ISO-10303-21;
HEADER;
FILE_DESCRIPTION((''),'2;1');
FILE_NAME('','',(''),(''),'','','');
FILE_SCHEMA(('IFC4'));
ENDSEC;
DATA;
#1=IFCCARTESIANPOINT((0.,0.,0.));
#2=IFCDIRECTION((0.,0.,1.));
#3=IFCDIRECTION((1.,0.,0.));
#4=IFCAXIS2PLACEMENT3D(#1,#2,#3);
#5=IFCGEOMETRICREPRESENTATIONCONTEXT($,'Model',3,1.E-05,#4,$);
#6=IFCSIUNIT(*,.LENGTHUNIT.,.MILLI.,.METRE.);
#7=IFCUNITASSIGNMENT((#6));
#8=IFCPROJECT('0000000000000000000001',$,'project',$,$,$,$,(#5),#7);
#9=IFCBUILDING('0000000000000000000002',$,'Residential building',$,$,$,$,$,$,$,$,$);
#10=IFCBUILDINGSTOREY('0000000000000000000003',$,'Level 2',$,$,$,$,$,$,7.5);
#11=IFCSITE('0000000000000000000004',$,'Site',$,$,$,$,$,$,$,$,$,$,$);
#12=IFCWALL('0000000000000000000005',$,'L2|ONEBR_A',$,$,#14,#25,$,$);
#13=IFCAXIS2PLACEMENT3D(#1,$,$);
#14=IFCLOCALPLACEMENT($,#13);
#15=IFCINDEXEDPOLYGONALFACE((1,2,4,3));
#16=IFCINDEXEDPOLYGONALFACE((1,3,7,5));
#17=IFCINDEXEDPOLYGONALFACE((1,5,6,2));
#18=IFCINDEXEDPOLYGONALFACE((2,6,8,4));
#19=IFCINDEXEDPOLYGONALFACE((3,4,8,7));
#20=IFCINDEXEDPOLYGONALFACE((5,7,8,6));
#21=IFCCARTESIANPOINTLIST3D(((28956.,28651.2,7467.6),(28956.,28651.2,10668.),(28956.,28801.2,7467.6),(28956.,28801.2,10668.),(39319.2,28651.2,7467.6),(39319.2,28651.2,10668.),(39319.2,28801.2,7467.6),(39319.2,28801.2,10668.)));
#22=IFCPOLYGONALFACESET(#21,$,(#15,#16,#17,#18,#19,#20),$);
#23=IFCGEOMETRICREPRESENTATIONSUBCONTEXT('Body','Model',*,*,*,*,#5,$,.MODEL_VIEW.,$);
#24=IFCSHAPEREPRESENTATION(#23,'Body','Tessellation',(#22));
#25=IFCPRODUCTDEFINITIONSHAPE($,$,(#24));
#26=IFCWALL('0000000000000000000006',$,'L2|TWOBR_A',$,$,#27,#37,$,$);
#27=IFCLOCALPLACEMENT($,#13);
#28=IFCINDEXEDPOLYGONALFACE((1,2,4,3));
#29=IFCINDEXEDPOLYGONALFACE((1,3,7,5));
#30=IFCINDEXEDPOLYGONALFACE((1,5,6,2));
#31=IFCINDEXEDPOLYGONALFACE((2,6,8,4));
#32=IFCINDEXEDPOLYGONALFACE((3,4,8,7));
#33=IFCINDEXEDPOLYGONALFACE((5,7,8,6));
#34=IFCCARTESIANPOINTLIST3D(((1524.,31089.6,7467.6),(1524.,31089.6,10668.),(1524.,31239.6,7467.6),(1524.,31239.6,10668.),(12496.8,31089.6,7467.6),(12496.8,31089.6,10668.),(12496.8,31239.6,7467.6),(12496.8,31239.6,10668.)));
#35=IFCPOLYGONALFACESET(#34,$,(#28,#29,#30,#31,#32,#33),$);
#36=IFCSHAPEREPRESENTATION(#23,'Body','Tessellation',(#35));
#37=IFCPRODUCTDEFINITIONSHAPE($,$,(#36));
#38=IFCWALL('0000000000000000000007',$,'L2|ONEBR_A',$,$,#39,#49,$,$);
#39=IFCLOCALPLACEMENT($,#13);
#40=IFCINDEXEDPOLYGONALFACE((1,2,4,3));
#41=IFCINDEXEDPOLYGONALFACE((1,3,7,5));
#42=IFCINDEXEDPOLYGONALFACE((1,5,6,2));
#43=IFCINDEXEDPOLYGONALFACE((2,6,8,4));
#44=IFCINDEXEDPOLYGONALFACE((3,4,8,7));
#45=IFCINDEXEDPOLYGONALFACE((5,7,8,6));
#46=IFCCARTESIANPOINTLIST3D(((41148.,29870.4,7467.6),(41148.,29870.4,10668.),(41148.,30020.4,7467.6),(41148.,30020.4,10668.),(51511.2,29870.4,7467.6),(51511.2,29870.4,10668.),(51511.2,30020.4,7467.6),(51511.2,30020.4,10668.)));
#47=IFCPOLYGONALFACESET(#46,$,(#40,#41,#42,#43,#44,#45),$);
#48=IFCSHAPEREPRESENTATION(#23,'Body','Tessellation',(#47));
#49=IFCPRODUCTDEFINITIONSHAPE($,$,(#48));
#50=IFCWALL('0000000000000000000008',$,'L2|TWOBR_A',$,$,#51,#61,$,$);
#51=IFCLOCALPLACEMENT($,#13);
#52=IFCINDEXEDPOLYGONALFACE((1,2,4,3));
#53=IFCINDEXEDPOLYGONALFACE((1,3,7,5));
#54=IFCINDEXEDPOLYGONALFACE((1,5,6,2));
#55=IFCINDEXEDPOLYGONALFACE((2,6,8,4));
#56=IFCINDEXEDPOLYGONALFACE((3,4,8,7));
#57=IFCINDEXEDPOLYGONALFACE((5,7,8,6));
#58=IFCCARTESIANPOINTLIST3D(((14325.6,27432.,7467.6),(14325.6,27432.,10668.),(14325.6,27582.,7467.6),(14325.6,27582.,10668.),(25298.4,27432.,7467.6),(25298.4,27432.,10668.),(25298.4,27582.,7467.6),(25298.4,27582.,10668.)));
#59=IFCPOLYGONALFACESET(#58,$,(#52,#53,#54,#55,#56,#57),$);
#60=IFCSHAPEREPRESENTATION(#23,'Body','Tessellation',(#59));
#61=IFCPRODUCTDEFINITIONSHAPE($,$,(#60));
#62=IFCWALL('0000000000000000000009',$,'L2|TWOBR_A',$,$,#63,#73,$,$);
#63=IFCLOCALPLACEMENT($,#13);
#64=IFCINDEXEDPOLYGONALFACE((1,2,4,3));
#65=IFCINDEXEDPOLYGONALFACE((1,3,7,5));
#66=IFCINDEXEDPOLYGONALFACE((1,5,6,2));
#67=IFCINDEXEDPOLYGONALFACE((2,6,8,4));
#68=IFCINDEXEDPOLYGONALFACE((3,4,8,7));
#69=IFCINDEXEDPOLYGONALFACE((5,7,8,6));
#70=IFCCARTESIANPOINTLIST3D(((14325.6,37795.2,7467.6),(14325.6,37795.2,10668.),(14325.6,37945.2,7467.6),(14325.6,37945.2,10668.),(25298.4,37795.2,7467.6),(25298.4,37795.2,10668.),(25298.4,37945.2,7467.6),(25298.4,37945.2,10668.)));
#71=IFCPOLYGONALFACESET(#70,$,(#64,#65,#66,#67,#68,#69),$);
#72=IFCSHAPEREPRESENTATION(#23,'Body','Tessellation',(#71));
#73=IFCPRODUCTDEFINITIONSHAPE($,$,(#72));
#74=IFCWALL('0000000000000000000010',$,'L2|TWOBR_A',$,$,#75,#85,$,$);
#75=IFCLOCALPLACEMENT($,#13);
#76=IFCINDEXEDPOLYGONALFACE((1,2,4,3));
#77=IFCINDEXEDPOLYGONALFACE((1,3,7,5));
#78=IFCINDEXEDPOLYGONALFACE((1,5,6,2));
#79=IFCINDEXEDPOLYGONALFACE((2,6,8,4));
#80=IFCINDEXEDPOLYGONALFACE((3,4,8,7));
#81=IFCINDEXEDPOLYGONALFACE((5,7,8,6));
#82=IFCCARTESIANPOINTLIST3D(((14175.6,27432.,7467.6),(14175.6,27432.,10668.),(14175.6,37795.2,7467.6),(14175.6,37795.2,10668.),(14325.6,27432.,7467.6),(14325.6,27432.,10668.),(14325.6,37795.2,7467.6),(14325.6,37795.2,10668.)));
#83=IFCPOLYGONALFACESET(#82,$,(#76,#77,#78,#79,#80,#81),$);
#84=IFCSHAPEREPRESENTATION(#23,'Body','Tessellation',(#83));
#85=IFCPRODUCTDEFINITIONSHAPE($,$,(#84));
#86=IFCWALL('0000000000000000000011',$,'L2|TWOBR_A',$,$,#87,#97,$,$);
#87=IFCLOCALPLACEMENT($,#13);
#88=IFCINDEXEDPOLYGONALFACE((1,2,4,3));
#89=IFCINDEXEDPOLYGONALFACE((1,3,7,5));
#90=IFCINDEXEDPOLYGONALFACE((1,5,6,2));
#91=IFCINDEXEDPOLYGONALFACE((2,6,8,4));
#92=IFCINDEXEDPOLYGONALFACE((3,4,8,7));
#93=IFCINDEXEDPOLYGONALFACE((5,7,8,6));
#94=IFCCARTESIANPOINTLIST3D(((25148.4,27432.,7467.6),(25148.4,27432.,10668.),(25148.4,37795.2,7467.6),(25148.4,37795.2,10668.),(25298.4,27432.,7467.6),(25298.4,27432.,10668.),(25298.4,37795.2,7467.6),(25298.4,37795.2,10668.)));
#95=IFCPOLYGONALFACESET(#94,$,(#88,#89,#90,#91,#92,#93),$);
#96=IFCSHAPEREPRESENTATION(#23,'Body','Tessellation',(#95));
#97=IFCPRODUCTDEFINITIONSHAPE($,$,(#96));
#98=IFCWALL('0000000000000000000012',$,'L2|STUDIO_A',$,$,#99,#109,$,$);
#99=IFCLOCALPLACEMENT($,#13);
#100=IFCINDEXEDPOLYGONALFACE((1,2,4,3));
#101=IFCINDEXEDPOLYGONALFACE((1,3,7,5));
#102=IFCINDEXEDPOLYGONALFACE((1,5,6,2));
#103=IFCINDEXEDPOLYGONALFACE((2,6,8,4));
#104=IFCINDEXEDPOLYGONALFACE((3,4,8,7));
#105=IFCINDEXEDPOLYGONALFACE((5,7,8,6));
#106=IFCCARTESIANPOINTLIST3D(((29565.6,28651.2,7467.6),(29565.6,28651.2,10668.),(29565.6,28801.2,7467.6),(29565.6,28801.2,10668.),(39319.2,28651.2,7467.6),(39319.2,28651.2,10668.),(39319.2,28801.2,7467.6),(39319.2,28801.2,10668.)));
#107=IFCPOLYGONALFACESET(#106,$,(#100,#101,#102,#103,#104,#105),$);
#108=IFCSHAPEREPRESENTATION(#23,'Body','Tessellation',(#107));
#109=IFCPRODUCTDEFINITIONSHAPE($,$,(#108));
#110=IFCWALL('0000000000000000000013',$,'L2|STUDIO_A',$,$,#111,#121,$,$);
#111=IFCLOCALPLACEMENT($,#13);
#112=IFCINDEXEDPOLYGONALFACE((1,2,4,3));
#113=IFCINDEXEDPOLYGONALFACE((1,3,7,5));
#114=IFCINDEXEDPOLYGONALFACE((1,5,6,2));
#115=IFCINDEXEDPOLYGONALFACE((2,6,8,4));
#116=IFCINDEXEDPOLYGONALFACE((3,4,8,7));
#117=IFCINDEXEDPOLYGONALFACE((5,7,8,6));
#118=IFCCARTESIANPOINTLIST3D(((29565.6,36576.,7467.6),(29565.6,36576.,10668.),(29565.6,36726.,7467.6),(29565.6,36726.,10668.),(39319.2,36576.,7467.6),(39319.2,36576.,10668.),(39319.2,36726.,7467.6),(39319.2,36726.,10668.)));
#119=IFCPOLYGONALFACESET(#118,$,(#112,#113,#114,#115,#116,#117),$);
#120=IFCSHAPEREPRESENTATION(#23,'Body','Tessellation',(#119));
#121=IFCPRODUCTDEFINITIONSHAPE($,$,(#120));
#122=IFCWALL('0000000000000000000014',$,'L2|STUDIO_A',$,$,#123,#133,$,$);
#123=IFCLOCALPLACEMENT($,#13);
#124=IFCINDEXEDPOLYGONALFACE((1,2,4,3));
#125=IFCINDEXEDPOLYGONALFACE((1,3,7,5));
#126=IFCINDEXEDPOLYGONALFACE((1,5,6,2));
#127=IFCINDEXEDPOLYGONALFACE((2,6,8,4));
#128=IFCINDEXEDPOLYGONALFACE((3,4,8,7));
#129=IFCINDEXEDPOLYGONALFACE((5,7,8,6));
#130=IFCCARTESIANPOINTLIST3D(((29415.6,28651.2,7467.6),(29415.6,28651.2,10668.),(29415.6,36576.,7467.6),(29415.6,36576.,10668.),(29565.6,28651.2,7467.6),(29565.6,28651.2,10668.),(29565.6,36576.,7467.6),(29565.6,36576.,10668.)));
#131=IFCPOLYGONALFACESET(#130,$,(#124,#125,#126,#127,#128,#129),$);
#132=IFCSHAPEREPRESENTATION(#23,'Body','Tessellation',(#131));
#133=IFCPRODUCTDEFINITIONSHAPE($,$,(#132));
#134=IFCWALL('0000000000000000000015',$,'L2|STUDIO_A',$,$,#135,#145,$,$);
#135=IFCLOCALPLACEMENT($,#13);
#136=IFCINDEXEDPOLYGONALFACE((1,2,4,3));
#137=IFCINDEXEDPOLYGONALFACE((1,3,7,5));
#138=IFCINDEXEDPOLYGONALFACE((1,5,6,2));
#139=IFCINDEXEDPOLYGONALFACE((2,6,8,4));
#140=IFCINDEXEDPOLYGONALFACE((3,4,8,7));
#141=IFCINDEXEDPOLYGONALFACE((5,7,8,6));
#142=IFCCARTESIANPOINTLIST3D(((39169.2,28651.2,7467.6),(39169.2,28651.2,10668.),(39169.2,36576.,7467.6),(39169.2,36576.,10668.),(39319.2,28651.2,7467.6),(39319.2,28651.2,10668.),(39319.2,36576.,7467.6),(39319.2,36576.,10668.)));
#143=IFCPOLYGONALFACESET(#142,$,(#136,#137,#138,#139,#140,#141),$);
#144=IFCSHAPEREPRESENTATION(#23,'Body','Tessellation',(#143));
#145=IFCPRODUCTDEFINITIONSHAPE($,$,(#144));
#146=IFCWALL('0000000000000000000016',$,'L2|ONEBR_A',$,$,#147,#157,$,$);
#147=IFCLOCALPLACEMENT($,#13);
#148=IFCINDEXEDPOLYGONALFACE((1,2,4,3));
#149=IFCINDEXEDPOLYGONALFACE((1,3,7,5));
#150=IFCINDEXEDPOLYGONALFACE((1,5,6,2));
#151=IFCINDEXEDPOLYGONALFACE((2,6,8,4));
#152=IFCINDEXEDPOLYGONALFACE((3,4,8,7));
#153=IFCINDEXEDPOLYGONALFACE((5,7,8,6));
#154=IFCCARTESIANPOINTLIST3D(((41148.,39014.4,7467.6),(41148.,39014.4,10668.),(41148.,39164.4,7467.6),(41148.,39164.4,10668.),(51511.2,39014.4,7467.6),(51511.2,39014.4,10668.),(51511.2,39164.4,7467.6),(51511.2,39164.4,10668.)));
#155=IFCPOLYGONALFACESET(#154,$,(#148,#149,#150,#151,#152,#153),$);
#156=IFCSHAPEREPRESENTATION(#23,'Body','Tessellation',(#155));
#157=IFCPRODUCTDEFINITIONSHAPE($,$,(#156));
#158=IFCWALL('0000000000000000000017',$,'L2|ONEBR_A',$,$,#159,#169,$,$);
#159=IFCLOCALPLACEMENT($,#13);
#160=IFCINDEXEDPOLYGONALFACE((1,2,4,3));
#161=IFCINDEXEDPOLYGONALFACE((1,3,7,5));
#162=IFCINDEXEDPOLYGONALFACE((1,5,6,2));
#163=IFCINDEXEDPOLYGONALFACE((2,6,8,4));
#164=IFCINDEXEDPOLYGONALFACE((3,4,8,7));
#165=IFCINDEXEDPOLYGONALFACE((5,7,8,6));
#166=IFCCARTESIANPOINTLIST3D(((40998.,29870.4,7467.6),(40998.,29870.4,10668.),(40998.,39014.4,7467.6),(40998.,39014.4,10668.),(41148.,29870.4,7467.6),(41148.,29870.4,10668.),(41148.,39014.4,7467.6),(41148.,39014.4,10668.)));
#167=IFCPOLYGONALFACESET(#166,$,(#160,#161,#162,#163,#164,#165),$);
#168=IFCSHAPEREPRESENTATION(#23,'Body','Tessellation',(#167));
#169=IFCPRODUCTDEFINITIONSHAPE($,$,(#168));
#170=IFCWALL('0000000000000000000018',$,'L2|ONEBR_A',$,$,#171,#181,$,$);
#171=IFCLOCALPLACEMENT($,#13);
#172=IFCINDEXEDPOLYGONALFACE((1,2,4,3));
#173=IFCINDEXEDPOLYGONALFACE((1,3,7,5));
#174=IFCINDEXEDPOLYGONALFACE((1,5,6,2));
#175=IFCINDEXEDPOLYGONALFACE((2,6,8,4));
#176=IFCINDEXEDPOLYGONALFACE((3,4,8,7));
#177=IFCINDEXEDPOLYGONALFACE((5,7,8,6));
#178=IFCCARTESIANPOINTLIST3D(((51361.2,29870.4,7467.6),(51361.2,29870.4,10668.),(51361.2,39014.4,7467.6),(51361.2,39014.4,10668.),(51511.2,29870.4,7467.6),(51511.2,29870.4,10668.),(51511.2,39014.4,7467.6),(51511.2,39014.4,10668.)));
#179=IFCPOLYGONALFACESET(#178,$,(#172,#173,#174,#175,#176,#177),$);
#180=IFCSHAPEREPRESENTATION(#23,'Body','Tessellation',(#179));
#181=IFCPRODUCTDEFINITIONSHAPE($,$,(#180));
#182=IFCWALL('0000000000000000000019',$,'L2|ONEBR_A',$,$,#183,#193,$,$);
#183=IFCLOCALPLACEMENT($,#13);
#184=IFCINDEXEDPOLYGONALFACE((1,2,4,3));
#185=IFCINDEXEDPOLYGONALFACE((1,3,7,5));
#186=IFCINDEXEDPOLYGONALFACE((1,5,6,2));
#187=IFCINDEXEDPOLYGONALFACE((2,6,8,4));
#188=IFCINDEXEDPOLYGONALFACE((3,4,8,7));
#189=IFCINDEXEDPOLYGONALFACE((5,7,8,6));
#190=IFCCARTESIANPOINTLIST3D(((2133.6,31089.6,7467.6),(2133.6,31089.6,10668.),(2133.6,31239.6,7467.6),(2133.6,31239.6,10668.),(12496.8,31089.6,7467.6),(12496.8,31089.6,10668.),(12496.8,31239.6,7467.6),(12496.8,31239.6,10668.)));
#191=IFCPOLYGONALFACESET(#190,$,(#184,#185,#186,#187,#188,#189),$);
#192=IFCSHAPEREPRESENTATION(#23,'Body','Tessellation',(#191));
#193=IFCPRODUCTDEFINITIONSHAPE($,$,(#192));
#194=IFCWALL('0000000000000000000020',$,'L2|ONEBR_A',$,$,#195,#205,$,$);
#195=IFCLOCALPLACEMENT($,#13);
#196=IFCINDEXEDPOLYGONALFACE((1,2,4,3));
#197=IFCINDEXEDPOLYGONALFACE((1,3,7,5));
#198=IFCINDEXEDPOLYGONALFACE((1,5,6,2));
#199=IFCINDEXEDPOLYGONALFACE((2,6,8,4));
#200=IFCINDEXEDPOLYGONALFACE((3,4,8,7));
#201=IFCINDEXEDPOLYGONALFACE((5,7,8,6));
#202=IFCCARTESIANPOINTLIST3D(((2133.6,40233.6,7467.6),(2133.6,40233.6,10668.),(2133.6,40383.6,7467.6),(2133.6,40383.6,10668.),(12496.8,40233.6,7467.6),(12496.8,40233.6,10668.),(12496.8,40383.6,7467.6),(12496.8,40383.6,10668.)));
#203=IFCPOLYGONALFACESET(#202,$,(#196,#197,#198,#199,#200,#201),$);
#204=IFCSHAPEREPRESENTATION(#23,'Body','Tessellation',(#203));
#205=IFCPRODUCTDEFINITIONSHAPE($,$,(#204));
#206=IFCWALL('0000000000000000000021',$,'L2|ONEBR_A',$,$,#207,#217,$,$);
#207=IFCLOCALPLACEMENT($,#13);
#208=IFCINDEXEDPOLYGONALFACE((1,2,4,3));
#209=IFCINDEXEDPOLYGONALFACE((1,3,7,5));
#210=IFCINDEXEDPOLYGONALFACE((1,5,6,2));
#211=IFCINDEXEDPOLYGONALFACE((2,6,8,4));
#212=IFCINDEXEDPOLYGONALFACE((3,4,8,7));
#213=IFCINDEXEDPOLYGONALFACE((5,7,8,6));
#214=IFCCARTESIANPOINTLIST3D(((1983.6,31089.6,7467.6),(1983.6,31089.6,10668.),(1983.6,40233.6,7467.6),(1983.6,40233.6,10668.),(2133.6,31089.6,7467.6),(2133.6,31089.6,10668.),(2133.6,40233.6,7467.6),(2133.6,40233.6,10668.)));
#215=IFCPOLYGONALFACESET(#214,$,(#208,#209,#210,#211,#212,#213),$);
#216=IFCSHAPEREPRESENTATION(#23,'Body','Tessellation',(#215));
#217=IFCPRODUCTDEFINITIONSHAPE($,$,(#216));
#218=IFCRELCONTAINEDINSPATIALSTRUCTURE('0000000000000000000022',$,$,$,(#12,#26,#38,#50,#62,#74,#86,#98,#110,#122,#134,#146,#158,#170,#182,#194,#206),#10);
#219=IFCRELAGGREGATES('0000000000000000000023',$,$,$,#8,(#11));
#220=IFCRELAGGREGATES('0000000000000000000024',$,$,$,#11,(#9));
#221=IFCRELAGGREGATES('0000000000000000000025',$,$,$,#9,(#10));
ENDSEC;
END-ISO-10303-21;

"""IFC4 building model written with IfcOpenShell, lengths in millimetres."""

from ifc_helpers import new_model, si_unit, frame, origin_with_axes, place, context, subcontext, project, spatial, indexed_curve, outline, extrude, element, save


model = new_model("IFC4")

# Units and contexts
model_context = context("Model", 3, precision=1e-05, world=origin_with_axes())
body_context = subcontext(model_context, "Body", "Model", "MODEL_VIEW")
ifc_project = project(units=[si_unit("LENGTHUNIT", "METRE", prefix="MILLI")], contexts=[model_context])

# Site, building, storey
site = spatial("IfcSite", under=ifc_project, Name="Site")
building = spatial("IfcBuilding", under=site, Name="Residential building")
storey = spatial("IfcBuildingStorey", under=building, Name="Level 2", Elevation=7.5)

# Walls
wall_1_placement = place(None, frame((28956.0, 28651.2, 7467.6), z_axis=(0.0, 0.0, 1.0), x_axis=(1.0, 0.0, 0.0)))
element("IfcWall", 1, at=wall_1_placement, inside=storey, Name="L2|ONEBR_A", context=body_context, shape_type="SweptSolid", body=[
    extrude(outline(indexed_curve([(0.0, 0.0), (0.0, 150.0), (10363.2, 150.0), (10363.2, 0.0), (0.0, 0.0)], self_intersect=False)), origin_with_axes(), (0.0, 0.0, 1.0), 3200.4),
])
wall_2_placement = place(None, frame((1524.0, 31089.6, 7467.6), z_axis=(0.0, 0.0, 1.0), x_axis=(1.0, 0.0, 0.0)))
element("IfcWall", 2, at=wall_2_placement, inside=storey, Name="L2|TWOBR_A", context=body_context, shape_type="SweptSolid", body=[
    extrude(outline(indexed_curve([(0.0, 0.0), (0.0, 150.0), (10972.8, 150.0), (10972.8, 0.0), (0.0, 0.0)], self_intersect=False)), origin_with_axes(), (0.0, 0.0, 1.0), 3200.4),
])
wall_3_placement = place(None, frame((41148.0, 29870.4, 7467.6), z_axis=(0.0, 0.0, 1.0), x_axis=(1.0, 0.0, 0.0)))
element("IfcWall", 3, at=wall_3_placement, inside=storey, Name="L2|ONEBR_A", context=body_context, shape_type="SweptSolid", body=[
    extrude(outline(indexed_curve([(0.0, 0.0), (0.0, 150.0), (10363.2, 150.0), (10363.2, 0.0), (0.0, 0.0)], self_intersect=False)), origin_with_axes(), (0.0, 0.0, 1.0), 3200.4),
])
for number, where, z_axis, x_axis, name in (
    (4, (14325.6, 27432.0, 7467.6), (0.0, 0.0, 1.0), (1.0, 0.0, 0.0), "L2|TWOBR_A"),
    (5, (14325.6, 37795.2, 7467.6), (0.0, 0.0, 1.0), (1.0, 0.0, 0.0), "L2|TWOBR_A"),
):
    element("IfcWall", number, at=place(None, frame(where, z_axis=z_axis, x_axis=x_axis)), inside=storey, Name=name, context=body_context, shape_type="SweptSolid", body=[
        extrude(outline(indexed_curve([(0.0, 0.0), (0.0, 150.0), (10972.8, 150.0), (10972.8, 0.0), (0.0, 0.0)], self_intersect=False)), origin_with_axes(), (0.0, 0.0, 1.0), 3200.4),
    ])
for number, where, z_axis, x_axis, name in (
    (6, (14325.6, 27432.0, 7467.6), (0.0, 0.0, 1.0), (0.0, 1.0, 0.0), "L2|TWOBR_A"),
    (7, (25298.4, 27432.0, 7467.6), (0.0, 0.0, 1.0), (0.0, 1.0, 0.0), "L2|TWOBR_A"),
):
    element("IfcWall", number, at=place(None, frame(where, z_axis=z_axis, x_axis=x_axis)), inside=storey, Name=name, context=body_context, shape_type="SweptSolid", body=[
        extrude(outline(indexed_curve([(0.0, 0.0), (0.0, 150.0), (10363.2, 150.0), (10363.2, 0.0), (0.0, 0.0)], self_intersect=False)), origin_with_axes(), (0.0, 0.0, 1.0), 3200.4),
    ])
for number, where, z_axis, x_axis, name in (
    (8, (29565.6, 28651.2, 7467.6), (0.0, 0.0, 1.0), (1.0, 0.0, 0.0), "L2|STUDIO_A"),
    (9, (29565.6, 36576.0, 7467.6), (0.0, 0.0, 1.0), (1.0, 0.0, 0.0), "L2|STUDIO_A"),
):
    element("IfcWall", number, at=place(None, frame(where, z_axis=z_axis, x_axis=x_axis)), inside=storey, Name=name, context=body_context, shape_type="SweptSolid", body=[
        extrude(outline(indexed_curve([(0.0, 0.0), (0.0, 150.0), (9753.6, 150.0), (9753.6, 0.0), (0.0, 0.0)], self_intersect=False)), origin_with_axes(), (0.0, 0.0, 1.0), 3200.4),
    ])
for number, where, z_axis, x_axis, name in (
    (10, (29565.6, 28651.2, 7467.6), (0.0, 0.0, 1.0), (0.0, 1.0, 0.0), "L2|STUDIO_A"),
    (11, (39319.2, 28651.2, 7467.6), (0.0, 0.0, 1.0), (0.0, 1.0, 0.0), "L2|STUDIO_A"),
):
    element("IfcWall", number, at=place(None, frame(where, z_axis=z_axis, x_axis=x_axis)), inside=storey, Name=name, context=body_context, shape_type="SweptSolid", body=[
        extrude(outline(indexed_curve([(0.0, 0.0), (0.0, 150.0), (7924.8, 150.0), (7924.8, 0.0), (0.0, 0.0)], self_intersect=False)), origin_with_axes(), (0.0, 0.0, 1.0), 3200.4),
    ])
for number, where, z_axis, x_axis, name in (
    (12, (41148.0, 39014.4, 7467.6), (0.0, 0.0, 1.0), (1.0, 0.0, 0.0), "L2|ONEBR_A"),
):
    element("IfcWall", number, at=place(None, frame(where, z_axis=z_axis, x_axis=x_axis)), inside=storey, Name=name, context=body_context, shape_type="SweptSolid", body=[
        extrude(outline(indexed_curve([(0.0, 0.0), (0.0, 150.0), (10363.2, 150.0), (10363.2, 0.0), (0.0, 0.0)], self_intersect=False)), origin_with_axes(), (0.0, 0.0, 1.0), 3200.4),
    ])
for number, where, z_axis, x_axis, name in (
    (13, (41148.0, 29870.4, 7467.6), (0.0, 0.0, 1.0), (0.0, 1.0, 0.0), "L2|ONEBR_A"),
    (14, (51511.2, 29870.4, 7467.6), (0.0, 0.0, 1.0), (0.0, 1.0, 0.0), "L2|ONEBR_A"),
):
    element("IfcWall", number, at=place(None, frame(where, z_axis=z_axis, x_axis=x_axis)), inside=storey, Name=name, context=body_context, shape_type="SweptSolid", body=[
        extrude(outline(indexed_curve([(0.0, 0.0), (0.0, 150.0), (9144.0, 150.0), (9144.0, 0.0), (0.0, 0.0)], self_intersect=False)), origin_with_axes(), (0.0, 0.0, 1.0), 3200.4),
    ])
for number, where, z_axis, x_axis, name in (
    (15, (2133.6, 31089.6, 7467.6), (0.0, 0.0, 1.0), (1.0, 0.0, 0.0), "L2|ONEBR_A"),
    (16, (2133.6, 40233.6, 7467.6), (0.0, 0.0, 1.0), (1.0, 0.0, 0.0), "L2|ONEBR_A"),
):
    element("IfcWall", number, at=place(None, frame(where, z_axis=z_axis, x_axis=x_axis)), inside=storey, Name=name, context=body_context, shape_type="SweptSolid", body=[
        extrude(outline(indexed_curve([(0.0, 0.0), (0.0, 150.0), (10363.2, 150.0), (10363.2, 0.0), (0.0, 0.0)], self_intersect=False)), origin_with_axes(), (0.0, 0.0, 1.0), 3200.4),
    ])
for number, where, z_axis, x_axis, name in (
    (17, (2133.6, 31089.6, 7467.6), (0.0, 0.0, 1.0), (0.0, 1.0, 0.0), "L2|ONEBR_A"),
):
    element("IfcWall", number, at=place(None, frame(where, z_axis=z_axis, x_axis=x_axis)), inside=storey, Name=name, context=body_context, shape_type="SweptSolid", body=[
        extrude(outline(indexed_curve([(0.0, 0.0), (0.0, 150.0), (9144.0, 150.0), (9144.0, 0.0), (0.0, 0.0)], self_intersect=False)), origin_with_axes(), (0.0, 0.0, 1.0), 3200.4),
    ])

save(model, "model.ifc")
